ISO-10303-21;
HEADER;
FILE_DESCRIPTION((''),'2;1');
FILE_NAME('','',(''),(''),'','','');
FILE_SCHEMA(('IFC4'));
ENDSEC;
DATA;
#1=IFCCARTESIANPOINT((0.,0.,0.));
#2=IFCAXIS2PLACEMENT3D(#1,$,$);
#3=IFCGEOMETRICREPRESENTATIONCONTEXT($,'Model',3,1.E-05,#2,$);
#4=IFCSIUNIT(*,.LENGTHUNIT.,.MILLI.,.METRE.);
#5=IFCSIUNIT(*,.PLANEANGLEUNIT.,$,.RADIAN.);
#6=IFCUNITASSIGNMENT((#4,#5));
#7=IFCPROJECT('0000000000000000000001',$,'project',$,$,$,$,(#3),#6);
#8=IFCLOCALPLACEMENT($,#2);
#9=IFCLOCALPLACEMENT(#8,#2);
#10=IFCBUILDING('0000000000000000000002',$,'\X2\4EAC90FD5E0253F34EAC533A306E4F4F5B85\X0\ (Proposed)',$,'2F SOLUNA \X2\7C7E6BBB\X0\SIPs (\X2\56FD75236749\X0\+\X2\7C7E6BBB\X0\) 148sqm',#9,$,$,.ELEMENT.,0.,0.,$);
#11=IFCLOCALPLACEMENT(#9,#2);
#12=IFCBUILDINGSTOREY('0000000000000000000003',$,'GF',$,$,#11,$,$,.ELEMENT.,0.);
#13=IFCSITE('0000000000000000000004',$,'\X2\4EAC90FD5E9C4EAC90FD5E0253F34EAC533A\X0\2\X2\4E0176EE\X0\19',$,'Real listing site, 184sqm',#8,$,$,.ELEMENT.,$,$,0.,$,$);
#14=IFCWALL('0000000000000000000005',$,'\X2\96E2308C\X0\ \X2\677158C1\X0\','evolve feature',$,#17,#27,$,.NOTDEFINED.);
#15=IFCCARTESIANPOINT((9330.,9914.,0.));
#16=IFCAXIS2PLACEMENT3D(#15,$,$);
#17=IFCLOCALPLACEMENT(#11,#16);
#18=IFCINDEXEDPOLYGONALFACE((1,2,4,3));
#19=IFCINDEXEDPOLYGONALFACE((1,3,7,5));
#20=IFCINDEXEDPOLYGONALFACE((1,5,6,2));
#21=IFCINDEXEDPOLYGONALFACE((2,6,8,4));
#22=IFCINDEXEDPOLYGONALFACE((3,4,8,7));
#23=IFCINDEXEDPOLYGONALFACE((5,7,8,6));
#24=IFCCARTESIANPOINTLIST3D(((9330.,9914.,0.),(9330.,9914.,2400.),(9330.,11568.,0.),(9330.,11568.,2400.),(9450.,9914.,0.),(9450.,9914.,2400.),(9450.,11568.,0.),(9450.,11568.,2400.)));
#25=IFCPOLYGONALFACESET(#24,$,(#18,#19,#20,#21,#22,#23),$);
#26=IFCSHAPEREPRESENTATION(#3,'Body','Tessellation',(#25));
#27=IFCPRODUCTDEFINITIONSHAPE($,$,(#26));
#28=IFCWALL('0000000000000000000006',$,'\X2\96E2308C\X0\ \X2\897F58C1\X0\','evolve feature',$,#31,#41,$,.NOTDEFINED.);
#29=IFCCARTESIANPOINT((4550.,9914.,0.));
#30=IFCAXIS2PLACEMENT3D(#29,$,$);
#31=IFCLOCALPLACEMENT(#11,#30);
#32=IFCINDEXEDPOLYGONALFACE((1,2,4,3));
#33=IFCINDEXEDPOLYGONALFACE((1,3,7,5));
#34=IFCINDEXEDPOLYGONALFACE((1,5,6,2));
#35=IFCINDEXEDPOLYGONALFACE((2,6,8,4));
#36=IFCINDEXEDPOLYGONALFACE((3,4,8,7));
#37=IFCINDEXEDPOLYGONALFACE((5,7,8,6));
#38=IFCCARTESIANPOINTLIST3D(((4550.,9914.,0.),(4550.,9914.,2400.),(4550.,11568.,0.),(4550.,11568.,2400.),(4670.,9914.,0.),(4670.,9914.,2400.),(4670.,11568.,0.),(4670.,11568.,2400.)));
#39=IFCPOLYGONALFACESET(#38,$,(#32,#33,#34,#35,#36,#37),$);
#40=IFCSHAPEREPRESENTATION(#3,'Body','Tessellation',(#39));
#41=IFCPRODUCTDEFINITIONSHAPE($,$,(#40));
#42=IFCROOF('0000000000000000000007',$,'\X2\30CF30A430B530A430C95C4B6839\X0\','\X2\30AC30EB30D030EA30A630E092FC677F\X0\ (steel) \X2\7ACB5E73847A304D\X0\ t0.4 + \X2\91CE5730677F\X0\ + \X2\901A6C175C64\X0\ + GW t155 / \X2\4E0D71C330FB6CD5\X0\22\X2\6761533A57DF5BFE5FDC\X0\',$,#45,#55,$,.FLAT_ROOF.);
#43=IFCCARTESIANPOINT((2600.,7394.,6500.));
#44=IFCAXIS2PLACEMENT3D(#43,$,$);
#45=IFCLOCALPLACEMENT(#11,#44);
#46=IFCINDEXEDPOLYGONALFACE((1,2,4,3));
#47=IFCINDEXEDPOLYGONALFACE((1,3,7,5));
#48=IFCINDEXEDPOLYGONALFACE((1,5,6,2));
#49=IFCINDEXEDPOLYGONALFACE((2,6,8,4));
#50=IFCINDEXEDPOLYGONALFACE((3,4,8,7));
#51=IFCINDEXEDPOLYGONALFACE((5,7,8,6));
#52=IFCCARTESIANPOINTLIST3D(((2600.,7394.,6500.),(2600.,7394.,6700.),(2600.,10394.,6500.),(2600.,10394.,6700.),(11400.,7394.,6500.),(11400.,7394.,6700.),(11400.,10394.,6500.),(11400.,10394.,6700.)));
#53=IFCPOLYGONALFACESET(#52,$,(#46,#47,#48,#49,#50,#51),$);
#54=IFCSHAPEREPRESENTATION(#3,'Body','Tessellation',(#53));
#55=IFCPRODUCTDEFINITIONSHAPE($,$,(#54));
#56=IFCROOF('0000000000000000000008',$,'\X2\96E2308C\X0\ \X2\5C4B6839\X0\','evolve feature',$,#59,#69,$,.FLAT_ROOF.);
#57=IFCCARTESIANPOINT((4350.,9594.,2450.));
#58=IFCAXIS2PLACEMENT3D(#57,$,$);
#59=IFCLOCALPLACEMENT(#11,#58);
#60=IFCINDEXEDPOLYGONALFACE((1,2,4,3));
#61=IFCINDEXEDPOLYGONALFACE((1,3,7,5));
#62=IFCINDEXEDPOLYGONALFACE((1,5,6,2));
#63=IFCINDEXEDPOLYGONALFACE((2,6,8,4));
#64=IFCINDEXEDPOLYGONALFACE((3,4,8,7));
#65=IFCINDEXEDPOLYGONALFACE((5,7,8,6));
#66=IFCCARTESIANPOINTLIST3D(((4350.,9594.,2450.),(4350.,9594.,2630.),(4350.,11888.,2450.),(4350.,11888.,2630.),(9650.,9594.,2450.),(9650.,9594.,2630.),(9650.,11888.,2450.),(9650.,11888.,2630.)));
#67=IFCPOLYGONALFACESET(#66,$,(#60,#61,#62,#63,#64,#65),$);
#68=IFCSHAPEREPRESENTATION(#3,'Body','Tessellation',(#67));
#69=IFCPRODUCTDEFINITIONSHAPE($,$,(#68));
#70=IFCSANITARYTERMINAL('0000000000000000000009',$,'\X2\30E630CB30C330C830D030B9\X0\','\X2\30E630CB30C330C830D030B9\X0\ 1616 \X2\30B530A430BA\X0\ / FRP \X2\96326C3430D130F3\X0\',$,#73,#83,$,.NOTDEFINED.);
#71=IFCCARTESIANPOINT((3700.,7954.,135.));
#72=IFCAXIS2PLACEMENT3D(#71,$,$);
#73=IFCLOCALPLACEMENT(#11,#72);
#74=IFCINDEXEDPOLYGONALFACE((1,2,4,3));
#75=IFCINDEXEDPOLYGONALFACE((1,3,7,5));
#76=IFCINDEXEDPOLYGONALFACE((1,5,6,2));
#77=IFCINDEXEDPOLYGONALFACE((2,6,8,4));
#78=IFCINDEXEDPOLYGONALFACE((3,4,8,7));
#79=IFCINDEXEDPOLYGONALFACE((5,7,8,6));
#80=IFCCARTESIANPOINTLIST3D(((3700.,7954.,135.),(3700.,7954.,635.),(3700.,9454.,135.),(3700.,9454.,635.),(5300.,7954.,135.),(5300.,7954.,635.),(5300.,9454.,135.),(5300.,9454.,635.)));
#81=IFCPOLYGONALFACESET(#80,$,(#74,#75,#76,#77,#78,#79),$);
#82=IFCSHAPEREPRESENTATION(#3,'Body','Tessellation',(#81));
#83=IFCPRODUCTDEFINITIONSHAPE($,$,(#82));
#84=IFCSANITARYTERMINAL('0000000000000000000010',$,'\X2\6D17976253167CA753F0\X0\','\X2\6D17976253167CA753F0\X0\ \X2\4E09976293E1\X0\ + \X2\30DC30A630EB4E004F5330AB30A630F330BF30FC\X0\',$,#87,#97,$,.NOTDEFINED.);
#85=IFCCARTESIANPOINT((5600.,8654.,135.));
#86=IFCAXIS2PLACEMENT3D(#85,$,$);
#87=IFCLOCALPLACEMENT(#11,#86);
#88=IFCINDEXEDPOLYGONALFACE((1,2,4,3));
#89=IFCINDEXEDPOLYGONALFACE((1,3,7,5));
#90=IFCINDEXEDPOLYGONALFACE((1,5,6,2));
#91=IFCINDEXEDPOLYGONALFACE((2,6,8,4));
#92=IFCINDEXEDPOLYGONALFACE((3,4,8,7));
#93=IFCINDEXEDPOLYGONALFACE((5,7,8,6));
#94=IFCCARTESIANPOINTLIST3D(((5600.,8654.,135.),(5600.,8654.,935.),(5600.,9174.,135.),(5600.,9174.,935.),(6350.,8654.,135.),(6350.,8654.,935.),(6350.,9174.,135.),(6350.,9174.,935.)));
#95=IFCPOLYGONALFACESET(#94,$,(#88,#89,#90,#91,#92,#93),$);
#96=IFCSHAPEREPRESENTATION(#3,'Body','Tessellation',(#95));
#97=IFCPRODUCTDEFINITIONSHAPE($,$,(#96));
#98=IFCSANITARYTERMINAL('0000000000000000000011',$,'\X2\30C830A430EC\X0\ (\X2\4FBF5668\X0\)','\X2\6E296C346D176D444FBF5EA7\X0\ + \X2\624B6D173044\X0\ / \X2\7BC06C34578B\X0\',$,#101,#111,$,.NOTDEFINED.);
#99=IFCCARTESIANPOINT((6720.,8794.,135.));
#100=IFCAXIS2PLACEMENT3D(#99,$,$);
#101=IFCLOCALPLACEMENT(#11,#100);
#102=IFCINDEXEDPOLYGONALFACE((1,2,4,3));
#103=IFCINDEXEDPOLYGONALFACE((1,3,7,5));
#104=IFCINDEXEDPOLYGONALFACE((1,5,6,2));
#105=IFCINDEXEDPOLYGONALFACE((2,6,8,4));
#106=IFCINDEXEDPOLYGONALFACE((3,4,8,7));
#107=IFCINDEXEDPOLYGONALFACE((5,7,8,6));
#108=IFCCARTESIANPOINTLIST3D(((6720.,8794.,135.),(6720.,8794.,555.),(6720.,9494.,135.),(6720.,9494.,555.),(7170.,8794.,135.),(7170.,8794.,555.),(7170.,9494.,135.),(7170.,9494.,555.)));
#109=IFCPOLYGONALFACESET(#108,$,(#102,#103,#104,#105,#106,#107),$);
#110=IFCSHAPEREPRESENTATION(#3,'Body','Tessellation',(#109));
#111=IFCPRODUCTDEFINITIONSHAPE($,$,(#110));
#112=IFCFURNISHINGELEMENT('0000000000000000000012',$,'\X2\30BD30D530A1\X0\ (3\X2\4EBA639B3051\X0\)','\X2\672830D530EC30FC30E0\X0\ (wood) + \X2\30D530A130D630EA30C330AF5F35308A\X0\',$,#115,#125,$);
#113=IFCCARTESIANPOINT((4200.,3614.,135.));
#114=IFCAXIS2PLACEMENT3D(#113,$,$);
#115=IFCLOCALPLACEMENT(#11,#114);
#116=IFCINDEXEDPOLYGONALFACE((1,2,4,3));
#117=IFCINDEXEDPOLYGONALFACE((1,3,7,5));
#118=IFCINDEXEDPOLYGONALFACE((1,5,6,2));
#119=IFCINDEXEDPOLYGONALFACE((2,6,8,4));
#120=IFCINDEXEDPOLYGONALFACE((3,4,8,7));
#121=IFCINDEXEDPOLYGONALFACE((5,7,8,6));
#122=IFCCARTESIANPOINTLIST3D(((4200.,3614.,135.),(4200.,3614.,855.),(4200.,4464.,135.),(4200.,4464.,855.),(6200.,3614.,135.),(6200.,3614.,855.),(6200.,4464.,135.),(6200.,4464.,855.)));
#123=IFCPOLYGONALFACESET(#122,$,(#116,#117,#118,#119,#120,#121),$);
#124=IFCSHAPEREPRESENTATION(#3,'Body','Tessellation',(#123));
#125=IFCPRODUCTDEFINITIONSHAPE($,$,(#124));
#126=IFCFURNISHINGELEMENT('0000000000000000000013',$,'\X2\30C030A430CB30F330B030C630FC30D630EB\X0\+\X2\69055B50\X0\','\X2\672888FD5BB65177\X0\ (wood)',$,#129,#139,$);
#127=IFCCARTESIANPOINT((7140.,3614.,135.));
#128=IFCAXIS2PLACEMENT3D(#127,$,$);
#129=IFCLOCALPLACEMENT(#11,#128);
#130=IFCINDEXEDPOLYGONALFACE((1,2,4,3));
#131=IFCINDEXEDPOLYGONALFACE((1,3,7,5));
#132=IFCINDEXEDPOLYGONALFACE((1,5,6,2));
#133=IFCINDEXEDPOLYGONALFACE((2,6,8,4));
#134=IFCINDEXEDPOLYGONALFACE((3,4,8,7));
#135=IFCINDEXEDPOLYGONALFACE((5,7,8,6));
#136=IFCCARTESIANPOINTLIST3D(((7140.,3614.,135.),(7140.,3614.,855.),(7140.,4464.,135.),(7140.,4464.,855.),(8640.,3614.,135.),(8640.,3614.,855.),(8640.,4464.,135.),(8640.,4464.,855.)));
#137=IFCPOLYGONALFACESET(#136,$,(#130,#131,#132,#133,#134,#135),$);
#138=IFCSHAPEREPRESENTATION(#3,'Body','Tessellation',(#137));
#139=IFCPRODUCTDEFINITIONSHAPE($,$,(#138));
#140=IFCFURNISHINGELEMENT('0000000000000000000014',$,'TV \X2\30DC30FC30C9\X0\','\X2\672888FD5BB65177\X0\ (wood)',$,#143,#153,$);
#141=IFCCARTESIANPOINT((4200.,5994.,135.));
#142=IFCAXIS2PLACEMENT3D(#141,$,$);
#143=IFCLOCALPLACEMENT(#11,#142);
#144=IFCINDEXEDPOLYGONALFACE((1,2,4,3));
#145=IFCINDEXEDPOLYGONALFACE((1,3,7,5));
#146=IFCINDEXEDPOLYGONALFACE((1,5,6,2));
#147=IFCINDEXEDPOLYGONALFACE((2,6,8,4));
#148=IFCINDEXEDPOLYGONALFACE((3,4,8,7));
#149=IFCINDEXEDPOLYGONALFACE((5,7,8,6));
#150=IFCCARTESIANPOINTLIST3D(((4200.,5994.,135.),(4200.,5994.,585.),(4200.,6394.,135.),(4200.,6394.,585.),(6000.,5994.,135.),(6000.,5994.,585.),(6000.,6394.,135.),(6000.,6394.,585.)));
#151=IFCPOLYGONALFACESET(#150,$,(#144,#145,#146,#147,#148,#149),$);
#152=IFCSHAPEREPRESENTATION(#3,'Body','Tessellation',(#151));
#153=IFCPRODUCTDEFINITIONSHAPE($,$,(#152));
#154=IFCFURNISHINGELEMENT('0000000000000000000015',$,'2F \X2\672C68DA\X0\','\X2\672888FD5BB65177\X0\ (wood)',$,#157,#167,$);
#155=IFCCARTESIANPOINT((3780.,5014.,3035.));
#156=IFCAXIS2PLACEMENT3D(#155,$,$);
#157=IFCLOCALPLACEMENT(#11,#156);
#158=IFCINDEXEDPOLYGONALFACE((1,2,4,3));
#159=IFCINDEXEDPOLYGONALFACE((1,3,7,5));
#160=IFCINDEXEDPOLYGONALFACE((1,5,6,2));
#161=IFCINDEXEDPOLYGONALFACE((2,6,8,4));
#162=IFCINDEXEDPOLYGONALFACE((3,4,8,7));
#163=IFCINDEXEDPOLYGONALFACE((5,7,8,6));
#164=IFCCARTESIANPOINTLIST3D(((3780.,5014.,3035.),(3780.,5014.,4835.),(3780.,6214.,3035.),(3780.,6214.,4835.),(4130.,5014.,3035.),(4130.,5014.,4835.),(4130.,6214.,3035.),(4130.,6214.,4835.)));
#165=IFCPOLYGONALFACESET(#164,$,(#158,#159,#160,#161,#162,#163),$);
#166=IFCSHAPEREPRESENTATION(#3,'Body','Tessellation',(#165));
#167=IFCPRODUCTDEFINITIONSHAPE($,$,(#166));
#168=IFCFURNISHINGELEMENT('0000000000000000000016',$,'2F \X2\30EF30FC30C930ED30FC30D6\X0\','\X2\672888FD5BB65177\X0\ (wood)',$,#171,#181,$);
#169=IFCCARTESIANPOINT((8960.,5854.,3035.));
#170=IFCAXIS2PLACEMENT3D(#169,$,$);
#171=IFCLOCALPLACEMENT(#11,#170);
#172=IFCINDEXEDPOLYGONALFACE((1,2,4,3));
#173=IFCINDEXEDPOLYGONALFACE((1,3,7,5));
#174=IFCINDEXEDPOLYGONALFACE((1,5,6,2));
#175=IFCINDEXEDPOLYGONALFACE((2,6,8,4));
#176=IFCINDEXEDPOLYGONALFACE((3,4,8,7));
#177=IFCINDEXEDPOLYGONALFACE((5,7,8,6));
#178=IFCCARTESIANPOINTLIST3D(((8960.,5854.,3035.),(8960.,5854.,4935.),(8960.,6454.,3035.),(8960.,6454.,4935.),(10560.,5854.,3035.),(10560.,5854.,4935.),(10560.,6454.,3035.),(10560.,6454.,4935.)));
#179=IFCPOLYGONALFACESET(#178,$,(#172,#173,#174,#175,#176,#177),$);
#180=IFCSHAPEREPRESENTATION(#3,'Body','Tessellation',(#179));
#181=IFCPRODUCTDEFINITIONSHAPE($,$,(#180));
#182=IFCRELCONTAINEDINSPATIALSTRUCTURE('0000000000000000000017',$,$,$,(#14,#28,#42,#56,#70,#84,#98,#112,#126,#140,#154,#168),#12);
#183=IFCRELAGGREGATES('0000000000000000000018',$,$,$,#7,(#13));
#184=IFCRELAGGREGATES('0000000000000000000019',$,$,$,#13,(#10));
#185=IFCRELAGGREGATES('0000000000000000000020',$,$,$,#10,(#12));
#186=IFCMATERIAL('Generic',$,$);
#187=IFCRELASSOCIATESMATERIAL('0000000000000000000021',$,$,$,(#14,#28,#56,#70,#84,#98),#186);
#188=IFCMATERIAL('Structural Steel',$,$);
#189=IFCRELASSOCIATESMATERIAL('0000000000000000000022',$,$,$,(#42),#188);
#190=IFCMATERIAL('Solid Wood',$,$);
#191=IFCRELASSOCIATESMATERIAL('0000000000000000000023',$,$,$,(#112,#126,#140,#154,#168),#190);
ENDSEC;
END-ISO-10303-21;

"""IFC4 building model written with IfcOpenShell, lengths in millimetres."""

from ifc_helpers import new_model, si_unit, frame, frame_2d, origin, place, context, project, spatial, rectangle, extrude, material, element, save


model = new_model("IFC4")

# Units and contexts
model_context = context("Model", 3, precision=1e-05, world=origin())
ifc_project = project(units=[si_unit("LENGTHUNIT", "METRE", prefix="MILLI"), si_unit("PLANEANGLEUNIT", "RADIAN")], contexts=[model_context])

# Site, building, storey
site_placement = place(None, origin())
site = spatial("IfcSite", under=ifc_project, at=site_placement, Name="京都府京都市右京区2丁目19", ObjectType="Real listing site, 184sqm", CompositionType="ELEMENT", RefElevation=0.0)
building_placement = place(site_placement, origin())
building = spatial("IfcBuilding", under=site, at=building_placement, Name="京都市右京区の住宅 (Proposed)", ObjectType="2F SOLUNA 籾殻SIPs (国産杉+籾殻) 148sqm", CompositionType="ELEMENT", ElevationOfRefHeight=0.0, ElevationOfTerrain=0.0)
storey_placement = place(building_placement, origin())
storey = spatial("IfcBuildingStorey", under=building, at=storey_placement, Name="GF", CompositionType="ELEMENT", Elevation=0.0)

# Shared definitions
ifc_material_1 = material(Name="Generic")

# Shared definitions
ifc_material_2 = material(Name="Solid Wood")

# Walls
wall_1_placement = place(storey_placement, frame((9330.0, 9914.0, 0.0)))
element("IfcWall", 1, at=wall_1_placement, inside=storey, material=ifc_material_1, Name="離れ 東壁", Description="evolve feature", PredefinedType="NOTDEFINED", context=model_context, shape_type="SweptSolid", body=[
    extrude(rectangle(XDim=120.0, YDim=1654.0, at=frame_2d((60.0, 827.0))), frame((9330.0, 9914.0, 0.0)), (0.0, 0.0, 1.0), 2400.0),
])
wall_2_placement = place(storey_placement, frame((4550.0, 9914.0, 0.0)))
element("IfcWall", 2, at=wall_2_placement, inside=storey, material=ifc_material_1, Name="離れ 西壁", Description="evolve feature", PredefinedType="NOTDEFINED", context=model_context, shape_type="SweptSolid", body=[
    extrude(rectangle(XDim=120.0, YDim=1654.0, at=frame_2d((60.0, 827.0))), frame((4550.0, 9914.0, 0.0)), (0.0, 0.0, 1.0), 2400.0),
])

# Roofs
ifc_material_3 = material(Name="Structural Steel")
roof_1_placement = place(storey_placement, frame((2600.0, 7394.0, 6500.0)))
element("IfcRoof", 3, at=roof_1_placement, inside=storey, material=ifc_material_3, Name="ハイサイド屋根", Description="ガルバリウム鋼板 (steel) 立平葺き t0.4 + 野地板 + 通気層 + GW t155 / 不燃・法22条区域対応", PredefinedType="FLAT_ROOF", context=model_context, shape_type="SweptSolid", body=[
    extrude(rectangle(XDim=8800.0, YDim=3000.0, at=frame_2d((4400.0, 1500.0))), frame((2600.0, 7394.0, 6500.0)), (0.0, 0.0, 1.0), 200.0),
])
roof_2_placement = place(storey_placement, frame((4350.0, 9594.0, 2450.0)))
element("IfcRoof", 4, at=roof_2_placement, inside=storey, material=ifc_material_1, Name="離れ 屋根", Description="evolve feature", PredefinedType="FLAT_ROOF", context=model_context, shape_type="SweptSolid", body=[
    extrude(rectangle(XDim=5300.0, YDim=2294.0, at=frame_2d((2650.0, 1147.0))), frame((4350.0, 9594.0, 2450.0)), (0.0, 0.0, 1.0), 180.0),
])

# Sanitary terminals
sanitary_terminal_1_placement = place(storey_placement, frame((3700.0, 7954.0, 135.0)))
element("IfcSanitaryTerminal", 5, at=sanitary_terminal_1_placement, inside=storey, material=ifc_material_1, Name="ユニットバス", Description="ユニットバス 1616 サイズ / FRP 防水パン", PredefinedType="NOTDEFINED", context=model_context, shape_type="SweptSolid", body=[
    extrude(rectangle(XDim=1600.0, YDim=1500.0, at=frame_2d((800.0, 750.0))), frame((3700.0, 7954.0, 135.0)), (0.0, 0.0, 1.0), 500.0),
])
sanitary_terminal_2_placement = place(storey_placement, frame((5600.0, 8654.0, 135.0)))
element("IfcSanitaryTerminal", 6, at=sanitary_terminal_2_placement, inside=storey, material=ifc_material_1, Name="洗面化粧台", Description="洗面化粧台 三面鏡 + ボウル一体カウンター", PredefinedType="NOTDEFINED", context=model_context, shape_type="SweptSolid", body=[
    extrude(rectangle(XDim=750.0, YDim=520.0, at=frame_2d((375.0, 260.0))), frame((5600.0, 8654.0, 135.0)), (0.0, 0.0, 1.0), 800.0),
])
sanitary_terminal_3_placement = place(storey_placement, frame((6720.0, 8794.0, 135.0)))
element("IfcSanitaryTerminal", 7, at=sanitary_terminal_3_placement, inside=storey, material=ifc_material_1, Name="トイレ (便器)", Description="温水洗浄便座 + 手洗い / 節水型", PredefinedType="NOTDEFINED", context=model_context, shape_type="SweptSolid", body=[
    extrude(rectangle(XDim=450.0, YDim=700.0, at=frame_2d((225.0, 350.0))), frame((6720.0, 8794.0, 135.0)), (0.0, 0.0, 1.0), 420.0),
])

# Furnishing elements
furnishing_1_placement = place(storey_placement, frame((4200.0, 3614.0, 135.0)))
element("IfcFurnishingElement", 8, at=furnishing_1_placement, inside=storey, material=ifc_material_2, Name="ソファ (3人掛け)", Description="木フレーム (wood) + ファブリック張り", context=model_context, shape_type="SweptSolid", body=[
    extrude(rectangle(XDim=2000.0, YDim=850.0, at=frame_2d((1000.0, 425.0))), frame((4200.0, 3614.0, 135.0)), (0.0, 0.0, 1.0), 720.0),
])
furnishing_2_placement = place(storey_placement, frame((7140.0, 3614.0, 135.0)))
element("IfcFurnishingElement", 9, at=furnishing_2_placement, inside=storey, material=ifc_material_2, Name="ダイニングテーブル+椅子", Description="木製家具 (wood)", context=model_context, shape_type="SweptSolid", body=[
    extrude(rectangle(XDim=1500.0, YDim=850.0, at=frame_2d((750.0, 425.0))), frame((7140.0, 3614.0, 135.0)), (0.0, 0.0, 1.0), 720.0),
])
furnishing_3_placement = place(storey_placement, frame((4200.0, 5994.0, 135.0)))
element("IfcFurnishingElement", 10, at=furnishing_3_placement, inside=storey, material=ifc_material_2, Name="TV ボード", Description="木製家具 (wood)", context=model_context, shape_type="SweptSolid", body=[
    extrude(rectangle(XDim=1800.0, YDim=400.0, at=frame_2d((900.0, 200.0))), frame((4200.0, 5994.0, 135.0)), (0.0, 0.0, 1.0), 450.0),
])
furnishing_4_placement = place(storey_placement, frame((3780.0, 5014.0, 3035.0)))
element("IfcFurnishingElement", 11, at=furnishing_4_placement, inside=storey, material=ifc_material_2, Name="2F 本棚", Description="木製家具 (wood)", context=model_context, shape_type="SweptSolid", body=[
    extrude(rectangle(XDim=350.0, YDim=1200.0, at=frame_2d((175.0, 600.0))), frame((3780.0, 5014.0, 3035.0)), (0.0, 0.0, 1.0), 1800.0),
])
furnishing_5_placement = place(storey_placement, frame((8960.0, 5854.0, 3035.0)))
element("IfcFurnishingElement", 12, at=furnishing_5_placement, inside=storey, material=ifc_material_2, Name="2F ワードローブ", Description="木製家具 (wood)", context=model_context, shape_type="SweptSolid", body=[
    extrude(rectangle(XDim=1600.0, YDim=600.0, at=frame_2d((800.0, 300.0))), frame((8960.0, 5854.0, 3035.0)), (0.0, 0.0, 1.0), 1900.0),
])

save(model, "model.ifc")
